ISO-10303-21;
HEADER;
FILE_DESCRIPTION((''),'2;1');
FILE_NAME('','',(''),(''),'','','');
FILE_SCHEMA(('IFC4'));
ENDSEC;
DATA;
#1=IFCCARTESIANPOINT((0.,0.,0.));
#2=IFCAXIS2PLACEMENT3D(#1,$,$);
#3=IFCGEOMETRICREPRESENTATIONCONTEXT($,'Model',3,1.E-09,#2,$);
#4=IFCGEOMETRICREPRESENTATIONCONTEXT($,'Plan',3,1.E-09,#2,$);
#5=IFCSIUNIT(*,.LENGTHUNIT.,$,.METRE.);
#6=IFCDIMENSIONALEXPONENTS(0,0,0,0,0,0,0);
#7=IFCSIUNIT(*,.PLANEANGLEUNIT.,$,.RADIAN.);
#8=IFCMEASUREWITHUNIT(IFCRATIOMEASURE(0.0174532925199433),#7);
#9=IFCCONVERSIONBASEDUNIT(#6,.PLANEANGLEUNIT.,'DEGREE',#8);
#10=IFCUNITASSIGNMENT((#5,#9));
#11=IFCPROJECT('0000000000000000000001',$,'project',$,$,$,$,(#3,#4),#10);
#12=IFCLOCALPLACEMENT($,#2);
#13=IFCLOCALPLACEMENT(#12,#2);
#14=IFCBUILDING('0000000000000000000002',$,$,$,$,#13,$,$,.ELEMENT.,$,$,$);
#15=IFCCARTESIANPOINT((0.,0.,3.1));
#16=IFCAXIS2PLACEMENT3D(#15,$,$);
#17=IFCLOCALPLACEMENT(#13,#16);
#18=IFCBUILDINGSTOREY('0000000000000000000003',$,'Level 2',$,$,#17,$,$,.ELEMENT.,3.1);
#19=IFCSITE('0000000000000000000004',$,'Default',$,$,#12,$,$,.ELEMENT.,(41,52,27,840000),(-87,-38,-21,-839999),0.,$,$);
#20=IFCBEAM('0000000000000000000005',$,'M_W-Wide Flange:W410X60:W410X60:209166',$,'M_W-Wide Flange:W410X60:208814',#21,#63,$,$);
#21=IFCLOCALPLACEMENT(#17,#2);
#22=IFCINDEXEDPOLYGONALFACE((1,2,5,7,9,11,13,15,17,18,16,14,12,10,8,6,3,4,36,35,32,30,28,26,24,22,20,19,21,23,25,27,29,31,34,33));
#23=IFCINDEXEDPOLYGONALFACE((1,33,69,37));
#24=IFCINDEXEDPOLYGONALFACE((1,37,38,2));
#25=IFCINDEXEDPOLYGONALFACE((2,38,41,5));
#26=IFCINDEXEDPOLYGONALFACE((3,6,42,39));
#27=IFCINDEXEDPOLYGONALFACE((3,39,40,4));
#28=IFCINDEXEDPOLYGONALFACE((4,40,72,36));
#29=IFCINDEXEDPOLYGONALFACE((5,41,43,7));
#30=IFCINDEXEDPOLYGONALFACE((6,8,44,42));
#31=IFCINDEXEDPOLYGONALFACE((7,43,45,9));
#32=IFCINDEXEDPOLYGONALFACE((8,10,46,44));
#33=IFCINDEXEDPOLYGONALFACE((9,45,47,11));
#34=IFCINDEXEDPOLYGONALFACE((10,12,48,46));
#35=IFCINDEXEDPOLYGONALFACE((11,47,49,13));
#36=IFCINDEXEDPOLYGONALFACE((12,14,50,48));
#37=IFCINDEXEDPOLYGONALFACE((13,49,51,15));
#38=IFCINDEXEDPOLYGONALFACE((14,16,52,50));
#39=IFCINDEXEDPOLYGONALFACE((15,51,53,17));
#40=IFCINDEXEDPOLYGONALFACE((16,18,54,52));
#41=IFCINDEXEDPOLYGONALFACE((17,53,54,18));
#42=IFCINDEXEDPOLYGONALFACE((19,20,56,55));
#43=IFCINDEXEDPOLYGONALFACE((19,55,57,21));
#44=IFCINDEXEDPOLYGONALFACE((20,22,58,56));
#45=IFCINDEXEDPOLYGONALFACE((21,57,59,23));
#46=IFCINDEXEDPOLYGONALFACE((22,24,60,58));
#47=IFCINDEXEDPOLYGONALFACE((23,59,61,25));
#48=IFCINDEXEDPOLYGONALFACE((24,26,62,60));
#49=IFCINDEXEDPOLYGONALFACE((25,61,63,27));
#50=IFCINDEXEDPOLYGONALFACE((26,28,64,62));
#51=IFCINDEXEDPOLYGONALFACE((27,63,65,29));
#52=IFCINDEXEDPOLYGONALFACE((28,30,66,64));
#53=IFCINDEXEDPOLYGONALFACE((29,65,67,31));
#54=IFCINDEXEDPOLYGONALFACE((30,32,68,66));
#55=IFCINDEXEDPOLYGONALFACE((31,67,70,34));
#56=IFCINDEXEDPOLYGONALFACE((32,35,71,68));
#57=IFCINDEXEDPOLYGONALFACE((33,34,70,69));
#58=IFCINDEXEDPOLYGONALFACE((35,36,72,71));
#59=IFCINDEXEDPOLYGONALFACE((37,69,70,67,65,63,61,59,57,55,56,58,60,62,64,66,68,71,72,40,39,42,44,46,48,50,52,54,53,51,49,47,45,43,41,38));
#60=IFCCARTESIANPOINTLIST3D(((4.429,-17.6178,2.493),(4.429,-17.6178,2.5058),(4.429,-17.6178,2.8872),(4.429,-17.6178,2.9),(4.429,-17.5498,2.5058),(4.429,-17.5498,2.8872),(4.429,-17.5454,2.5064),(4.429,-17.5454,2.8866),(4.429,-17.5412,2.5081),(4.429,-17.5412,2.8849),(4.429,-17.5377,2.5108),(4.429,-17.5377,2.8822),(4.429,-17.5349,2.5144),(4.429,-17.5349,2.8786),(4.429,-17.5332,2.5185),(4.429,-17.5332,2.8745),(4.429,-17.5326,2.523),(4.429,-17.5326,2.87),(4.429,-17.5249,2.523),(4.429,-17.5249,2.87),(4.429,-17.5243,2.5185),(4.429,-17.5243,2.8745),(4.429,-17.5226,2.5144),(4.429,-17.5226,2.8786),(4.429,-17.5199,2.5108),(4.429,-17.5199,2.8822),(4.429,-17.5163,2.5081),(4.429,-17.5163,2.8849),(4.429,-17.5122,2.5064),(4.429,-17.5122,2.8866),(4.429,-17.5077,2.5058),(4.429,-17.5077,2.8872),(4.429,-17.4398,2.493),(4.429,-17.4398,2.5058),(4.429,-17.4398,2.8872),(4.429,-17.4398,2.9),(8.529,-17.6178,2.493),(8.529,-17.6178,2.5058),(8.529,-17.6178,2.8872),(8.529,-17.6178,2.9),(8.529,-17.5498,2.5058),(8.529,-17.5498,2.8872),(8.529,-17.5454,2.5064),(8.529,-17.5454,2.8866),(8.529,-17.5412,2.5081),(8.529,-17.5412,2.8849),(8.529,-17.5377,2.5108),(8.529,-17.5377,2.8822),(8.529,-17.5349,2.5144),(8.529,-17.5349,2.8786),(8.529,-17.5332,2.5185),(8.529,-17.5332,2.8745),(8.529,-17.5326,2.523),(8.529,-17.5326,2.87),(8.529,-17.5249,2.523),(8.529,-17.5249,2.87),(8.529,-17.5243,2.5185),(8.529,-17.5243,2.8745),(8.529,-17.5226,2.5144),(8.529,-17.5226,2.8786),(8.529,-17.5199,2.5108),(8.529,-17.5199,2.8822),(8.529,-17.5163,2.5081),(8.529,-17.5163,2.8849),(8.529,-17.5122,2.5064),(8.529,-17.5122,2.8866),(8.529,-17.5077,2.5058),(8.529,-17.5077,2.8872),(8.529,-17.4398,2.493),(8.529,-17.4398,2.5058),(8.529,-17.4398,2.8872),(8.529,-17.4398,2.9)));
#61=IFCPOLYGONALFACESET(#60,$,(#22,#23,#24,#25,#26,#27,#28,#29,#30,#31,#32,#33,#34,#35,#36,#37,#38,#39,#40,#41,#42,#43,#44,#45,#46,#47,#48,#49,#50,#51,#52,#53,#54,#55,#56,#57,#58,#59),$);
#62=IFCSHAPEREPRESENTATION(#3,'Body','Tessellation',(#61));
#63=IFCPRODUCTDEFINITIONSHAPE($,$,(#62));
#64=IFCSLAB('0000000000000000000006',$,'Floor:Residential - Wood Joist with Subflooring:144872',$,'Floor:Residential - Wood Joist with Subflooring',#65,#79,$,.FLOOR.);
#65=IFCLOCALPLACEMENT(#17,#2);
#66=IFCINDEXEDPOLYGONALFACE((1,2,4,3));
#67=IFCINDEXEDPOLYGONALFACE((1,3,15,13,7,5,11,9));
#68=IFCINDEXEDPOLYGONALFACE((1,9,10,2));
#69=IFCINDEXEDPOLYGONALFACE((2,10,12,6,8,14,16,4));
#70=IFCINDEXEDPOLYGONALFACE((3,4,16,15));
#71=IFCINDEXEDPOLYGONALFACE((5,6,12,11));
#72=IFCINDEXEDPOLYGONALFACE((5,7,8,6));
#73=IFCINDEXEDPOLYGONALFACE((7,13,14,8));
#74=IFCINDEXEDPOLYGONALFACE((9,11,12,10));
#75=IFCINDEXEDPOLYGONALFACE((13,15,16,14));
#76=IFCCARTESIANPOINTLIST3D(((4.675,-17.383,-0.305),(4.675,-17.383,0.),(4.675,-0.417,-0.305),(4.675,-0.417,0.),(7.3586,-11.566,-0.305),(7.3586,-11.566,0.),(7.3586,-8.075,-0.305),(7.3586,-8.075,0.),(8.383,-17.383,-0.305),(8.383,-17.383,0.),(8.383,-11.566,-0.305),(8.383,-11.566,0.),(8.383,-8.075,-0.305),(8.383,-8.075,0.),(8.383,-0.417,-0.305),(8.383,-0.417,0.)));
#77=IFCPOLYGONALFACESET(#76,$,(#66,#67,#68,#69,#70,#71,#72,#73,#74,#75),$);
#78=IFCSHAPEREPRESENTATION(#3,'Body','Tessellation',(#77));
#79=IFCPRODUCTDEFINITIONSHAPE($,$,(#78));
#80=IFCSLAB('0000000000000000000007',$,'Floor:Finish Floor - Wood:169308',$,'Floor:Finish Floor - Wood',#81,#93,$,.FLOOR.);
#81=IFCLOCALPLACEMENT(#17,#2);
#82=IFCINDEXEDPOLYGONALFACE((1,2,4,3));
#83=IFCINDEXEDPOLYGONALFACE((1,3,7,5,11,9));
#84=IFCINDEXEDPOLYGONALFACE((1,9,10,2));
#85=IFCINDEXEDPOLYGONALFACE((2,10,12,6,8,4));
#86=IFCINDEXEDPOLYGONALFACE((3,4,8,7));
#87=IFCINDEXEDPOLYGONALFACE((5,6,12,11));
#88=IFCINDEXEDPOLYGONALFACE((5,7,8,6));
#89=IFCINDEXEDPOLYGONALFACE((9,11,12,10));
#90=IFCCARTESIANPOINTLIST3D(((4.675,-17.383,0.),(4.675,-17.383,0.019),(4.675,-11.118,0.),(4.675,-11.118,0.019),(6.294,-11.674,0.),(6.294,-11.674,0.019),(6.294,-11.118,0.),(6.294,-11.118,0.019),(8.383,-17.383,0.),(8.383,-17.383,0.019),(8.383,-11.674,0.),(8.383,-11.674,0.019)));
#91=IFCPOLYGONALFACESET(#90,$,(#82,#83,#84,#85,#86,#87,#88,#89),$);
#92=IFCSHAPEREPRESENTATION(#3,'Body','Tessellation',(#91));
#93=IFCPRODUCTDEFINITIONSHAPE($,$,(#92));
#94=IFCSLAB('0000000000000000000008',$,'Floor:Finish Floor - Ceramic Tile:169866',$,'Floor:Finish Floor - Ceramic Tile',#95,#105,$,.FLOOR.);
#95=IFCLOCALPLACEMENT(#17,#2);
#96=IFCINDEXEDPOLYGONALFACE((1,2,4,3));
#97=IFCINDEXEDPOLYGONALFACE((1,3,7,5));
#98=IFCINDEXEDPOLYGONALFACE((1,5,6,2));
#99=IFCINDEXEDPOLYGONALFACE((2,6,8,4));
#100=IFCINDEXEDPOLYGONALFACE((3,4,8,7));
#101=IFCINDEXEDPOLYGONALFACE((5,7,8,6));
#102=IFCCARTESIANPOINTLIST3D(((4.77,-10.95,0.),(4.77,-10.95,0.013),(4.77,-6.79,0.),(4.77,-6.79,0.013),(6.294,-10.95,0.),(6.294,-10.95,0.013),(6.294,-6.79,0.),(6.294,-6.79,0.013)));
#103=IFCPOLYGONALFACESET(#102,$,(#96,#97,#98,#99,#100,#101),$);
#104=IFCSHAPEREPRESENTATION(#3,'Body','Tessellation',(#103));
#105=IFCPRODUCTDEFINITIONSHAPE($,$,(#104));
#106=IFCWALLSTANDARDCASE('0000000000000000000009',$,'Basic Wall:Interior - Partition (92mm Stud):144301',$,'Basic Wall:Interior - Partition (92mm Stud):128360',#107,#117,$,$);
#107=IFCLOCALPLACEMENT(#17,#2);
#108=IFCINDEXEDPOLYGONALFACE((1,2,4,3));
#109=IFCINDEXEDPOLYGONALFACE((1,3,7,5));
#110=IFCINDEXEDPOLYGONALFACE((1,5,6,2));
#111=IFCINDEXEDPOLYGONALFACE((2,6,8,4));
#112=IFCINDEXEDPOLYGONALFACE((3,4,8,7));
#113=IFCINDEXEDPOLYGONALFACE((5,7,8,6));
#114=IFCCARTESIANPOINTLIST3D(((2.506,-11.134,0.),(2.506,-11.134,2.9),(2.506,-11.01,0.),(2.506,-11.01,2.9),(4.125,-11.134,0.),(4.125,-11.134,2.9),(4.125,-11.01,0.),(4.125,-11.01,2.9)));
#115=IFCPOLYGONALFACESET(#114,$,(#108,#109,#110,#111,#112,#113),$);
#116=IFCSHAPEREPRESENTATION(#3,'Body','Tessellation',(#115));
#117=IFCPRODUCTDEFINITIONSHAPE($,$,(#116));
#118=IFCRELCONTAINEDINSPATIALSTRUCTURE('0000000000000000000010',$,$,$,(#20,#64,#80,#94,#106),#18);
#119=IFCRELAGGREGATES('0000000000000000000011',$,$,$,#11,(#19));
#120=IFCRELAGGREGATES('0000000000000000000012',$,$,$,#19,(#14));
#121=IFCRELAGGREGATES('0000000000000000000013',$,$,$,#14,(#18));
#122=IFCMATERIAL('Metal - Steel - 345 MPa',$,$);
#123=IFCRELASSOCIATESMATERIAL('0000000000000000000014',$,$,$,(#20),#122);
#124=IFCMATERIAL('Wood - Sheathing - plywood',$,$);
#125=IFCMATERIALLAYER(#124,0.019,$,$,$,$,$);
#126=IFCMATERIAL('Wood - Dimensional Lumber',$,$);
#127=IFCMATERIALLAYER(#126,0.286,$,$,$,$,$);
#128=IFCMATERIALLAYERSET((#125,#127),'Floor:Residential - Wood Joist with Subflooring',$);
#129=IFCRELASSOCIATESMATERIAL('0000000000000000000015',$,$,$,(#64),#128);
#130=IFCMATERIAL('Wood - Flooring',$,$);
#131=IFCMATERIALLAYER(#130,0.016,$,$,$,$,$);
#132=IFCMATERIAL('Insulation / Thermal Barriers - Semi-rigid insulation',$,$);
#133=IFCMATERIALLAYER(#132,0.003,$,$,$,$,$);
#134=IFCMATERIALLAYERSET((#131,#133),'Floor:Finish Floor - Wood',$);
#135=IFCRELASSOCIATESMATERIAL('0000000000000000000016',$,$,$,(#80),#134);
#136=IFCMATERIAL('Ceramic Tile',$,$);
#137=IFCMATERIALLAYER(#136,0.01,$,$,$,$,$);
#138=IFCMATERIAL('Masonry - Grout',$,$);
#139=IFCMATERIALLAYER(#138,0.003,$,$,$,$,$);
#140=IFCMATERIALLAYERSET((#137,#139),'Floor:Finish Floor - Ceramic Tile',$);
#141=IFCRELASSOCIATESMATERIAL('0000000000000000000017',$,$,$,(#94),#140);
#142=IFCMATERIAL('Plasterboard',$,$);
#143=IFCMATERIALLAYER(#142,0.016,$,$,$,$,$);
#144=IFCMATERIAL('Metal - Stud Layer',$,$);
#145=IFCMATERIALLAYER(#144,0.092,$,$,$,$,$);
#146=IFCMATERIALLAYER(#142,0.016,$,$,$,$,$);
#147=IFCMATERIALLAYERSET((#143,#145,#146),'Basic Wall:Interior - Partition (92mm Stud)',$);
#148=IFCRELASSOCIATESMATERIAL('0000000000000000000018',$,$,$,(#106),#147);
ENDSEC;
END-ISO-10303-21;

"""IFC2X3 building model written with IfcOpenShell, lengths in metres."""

from ifc_helpers import new_model, entity, si_unit, converted_unit, frame, frame_2d, origin, place, context, project, spatial, polyline, circle_curve, parameter, trimmed, segment, composite_curve, rectangle, outline, extrude, material, layer, layer_set, layer_usage, element, save


model = new_model("IFC2X3")

# Units and contexts
model_context = context("Model", 3, precision=1e-09, world=origin())
plan_context = context("Plan", 3, precision=1e-09, world=origin())
ifc_project = project(units=[si_unit("LENGTHUNIT", "METRE"), converted_unit("PLANEANGLEUNIT", "DEGREE", entity("IfcRatioMeasure", 0.0174532925199433), si_unit("PLANEANGLEUNIT", "RADIAN"), dimensions=[0, 0, 0, 0, 0, 0, 0])], contexts=[model_context, plan_context])

# Site, building, storey
site_placement = place(None, origin())
site = spatial("IfcSite", under=ifc_project, at=site_placement, Name="Default", CompositionType="ELEMENT", RefLatitude=(41, 52, 27, 840000), RefLongitude=(-87, -38, -21, -839999), RefElevation=0.0)
building_placement = place(site_placement, origin())
building = spatial("IfcBuilding", under=site, at=building_placement, CompositionType="ELEMENT")
storey_placement = place(building_placement, frame((0.0, 0.0, 3.1)))
storey = spatial("IfcBuildingStorey", under=building, at=storey_placement, Name="Level 2", CompositionType="ELEMENT", Elevation=3.1)

# Beam
ifc_material_1 = material(Name="Metal - Steel - 345 MPa")
beam_placement = place(storey_placement, frame((4.429, -17.5288, 2.9), z_axis=(0.0, 0.0, 1.0), x_axis=(0.0, -1.0, 0.0)))
element("IfcBeam", 1, at=beam_placement, inside=storey, material=ifc_material_1, Name="M_W-Wide Flange:W410X60:W410X60:209166", ObjectType="M_W-Wide Flange:W410X60:208814", context=model_context, shape_type="SweptSolid", body=[
    extrude(outline(composite_curve([segment(polyline([(-0.089, -0.1907), (-0.089, -0.2035)]), True, "CONTINUOUS"), segment(polyline([(-0.089, -0.2035), (0.089, -0.2035)]), True, "CONTINUOUS"), segment(polyline([(0.089, -0.2035), (0.089, -0.1907)]), True, "CONTINUOUS"), segment(polyline([(0.089, -0.1907), (0.021, -0.1907)]), True, "CONTINUOUS"), segment(trimmed(circle_curve(frame_2d((0.021, -0.1735), x_axis=(0.0, -1.0)), 0.0172), [parameter(270.0)], [parameter(360.0)], True, "PARAMETER"), False, "CONTINUOUS"), segment(polyline([(0.0038, -0.1735), (0.0038, 0.1735)]), True, "CONTINUOUS"), segment(trimmed(circle_curve(frame_2d((0.021, 0.1735), x_axis=(-1.0, 0.0)), 0.0172), [parameter(270.0)], [parameter(360.0)], True, "PARAMETER"), False, "CONTINUOUS"), segment(polyline([(0.021, 0.1907), (0.089, 0.1907)]), True, "CONTINUOUS"), segment(polyline([(0.089, 0.1907), (0.089, 0.2035)]), True, "CONTINUOUS"), segment(polyline([(0.089, 0.2035), (-0.089, 0.2035)]), True, "CONTINUOUS"), segment(polyline([(-0.089, 0.2035), (-0.089, 0.1907)]), True, "CONTINUOUS"), segment(polyline([(-0.089, 0.1907), (-0.0211, 0.1907)]), True, "CONTINUOUS"), segment(trimmed(circle_curve(frame_2d((-0.0211, 0.1735), x_axis=(0.0, 1.0)), 0.0172), [parameter(270.0)], [parameter(0.0)], True, "PARAMETER"), False, "CONTINUOUS"), segment(polyline([(-0.0039, 0.1735), (-0.0039, -0.1735)]), True, "CONTINUOUS"), segment(trimmed(circle_curve(frame_2d((-0.0211, -0.1735), x_axis=(1.0, 0.0)), 0.0172), [parameter(270.0)], [parameter(0.0)], True, "PARAMETER"), False, "CONTINUOUS"), segment(polyline([(-0.0211, -0.1907), (-0.089, -0.1907)]), True, "CONTINUOUS")], self_intersect=False)), frame((0.0, 0.0, -0.2035), z_axis=(0.0, -1.0, 0.0), x_axis=(1.0, 0.0, 0.0)), (0.0, 0.0, -1.0), 4.1),
])

# Slabs
ifc_material_2 = material(Name="Wood - Sheathing - plywood")
ifc_layer_1 = layer(ifc_material_2, 0.019)
ifc_material_3 = material(Name="Wood - Dimensional Lumber")
ifc_layer_2 = layer(ifc_material_3, 0.286)
ifc_layer_set_1 = layer_set([ifc_layer_1, ifc_layer_2], Name="Floor:Residential - Wood Joist with Subflooring")
ifc_layer_usage_1 = layer_usage(ifc_layer_set_1, "AXIS3", "POSITIVE", 0.0)
slab_1_placement = place(storey_placement, frame((4.675, -17.383, -0.305)))
element("IfcSlab", 2, at=slab_1_placement, inside=storey, material=ifc_layer_usage_1, Name="Floor:Residential - Wood Joist with Subflooring:144872", ObjectType="Floor:Residential - Wood Joist with Subflooring", PredefinedType="FLOOR", context=model_context, shape_type="SweptSolid", body=[
    extrude(outline(polyline([(-1.854, 8.483), (-1.854, 0.825), (-0.8296, 0.825), (-0.8296, -2.666), (-1.854, -2.666), (-1.854, -8.483), (1.854, -8.483), (1.854, 8.483), (-1.854, 8.483)])), frame((1.854, 8.483, 0.305), z_axis=(0.0, 0.0, -1.0), x_axis=(-1.0, 0.0, 0.0)), (0.0, 0.0, 1.0), 0.305),
])
ifc_material_4 = material(Name="Wood - Flooring")
ifc_layer_3 = layer(ifc_material_4, 0.016)
ifc_material_5 = material(Name="Insulation / Thermal Barriers - Semi-rigid insulation")
ifc_layer_4 = layer(ifc_material_5, 0.003)
ifc_layer_set_2 = layer_set([ifc_layer_3, ifc_layer_4], Name="Floor:Finish Floor - Wood")
ifc_layer_usage_2 = layer_usage(ifc_layer_set_2, "AXIS3", "POSITIVE", 0.0)
slab_2_placement = place(storey_placement, frame((4.675, -17.383, 0.0)))
element("IfcSlab", 3, at=slab_2_placement, inside=storey, material=ifc_layer_usage_2, Name="Floor:Finish Floor - Wood:169308", ObjectType="Floor:Finish Floor - Wood", PredefinedType="FLOOR", context=model_context, shape_type="SweptSolid", body=[
    extrude(outline(polyline([(-1.854, 2.5765), (-1.854, -3.1325), (1.854, -3.1325), (1.854, 3.1325), (0.235, 3.1325), (0.235, 2.5765), (-1.854, 2.5765)])), frame((1.854, 3.1325, 0.019), z_axis=(0.0, 0.0, -1.0), x_axis=(-1.0, 0.0, 0.0)), (0.0, 0.0, 1.0), 0.019),
])
ifc_material_6 = material(Name="Ceramic Tile")
ifc_layer_5 = layer(ifc_material_6, 0.01)
ifc_material_7 = material(Name="Masonry - Grout")
ifc_layer_6 = layer(ifc_material_7, 0.003)
ifc_layer_set_3 = layer_set([ifc_layer_5, ifc_layer_6], Name="Floor:Finish Floor - Ceramic Tile")
ifc_layer_usage_3 = layer_usage(ifc_layer_set_3, "AXIS3", "POSITIVE", 0.0)
slab_3_placement = place(storey_placement, frame((4.77, -10.95, 0.0)))
element("IfcSlab", 4, at=slab_3_placement, inside=storey, material=ifc_layer_usage_3, Name="Floor:Finish Floor - Ceramic Tile:169866", ObjectType="Floor:Finish Floor - Ceramic Tile", PredefinedType="FLOOR", context=model_context, shape_type="SweptSolid", body=[
    extrude(rectangle(XDim=4.16, YDim=1.524, at=frame_2d((0.0, 0.0), x_axis=(0.0, -1.0))), frame((0.762, 2.08, 0.013), z_axis=(0.0, 0.0, -1.0), x_axis=(-1.0, 0.0, 0.0)), (0.0, 0.0, 1.0), 0.013),
])

# Shared definitions
ifc_material_8 = material(Name="Metal - Stud Layer")
ifc_material_9 = material(Name="Plasterboard")

# Wall
ifc_layer_7 = layer(ifc_material_9, 0.016)
ifc_layer_8 = layer(ifc_material_8, 0.092)
ifc_layer_9 = layer(ifc_material_9, 0.016)
ifc_layer_set_4 = layer_set([ifc_layer_7, ifc_layer_8, ifc_layer_9], Name="Basic Wall:Interior - Partition (92mm Stud)")
ifc_layer_usage_4 = layer_usage(ifc_layer_set_4, "AXIS2", "NEGATIVE", 0.062)
wall_1_placement = place(storey_placement, frame((4.125, -11.072, 0.0), z_axis=(0.0, 0.0, 1.0), x_axis=(-1.0, 0.0, 0.0)))
element("IfcWallStandardCase", 5, at=wall_1_placement, inside=storey, material=ifc_layer_usage_4, Name="Basic Wall:Interior - Partition (92mm Stud):144301", ObjectType="Basic Wall:Interior - Partition (92mm Stud):128360", context=model_context, shape_type="SweptSolid", body=[
    extrude(rectangle(XDim=1.619, YDim=0.124, at=frame_2d((0.8095, 0.0), x_axis=(-1.0, 0.0))), origin(), (0.0, 0.0, 1.0), 2.9),
])

save(model, "model.ifc")
